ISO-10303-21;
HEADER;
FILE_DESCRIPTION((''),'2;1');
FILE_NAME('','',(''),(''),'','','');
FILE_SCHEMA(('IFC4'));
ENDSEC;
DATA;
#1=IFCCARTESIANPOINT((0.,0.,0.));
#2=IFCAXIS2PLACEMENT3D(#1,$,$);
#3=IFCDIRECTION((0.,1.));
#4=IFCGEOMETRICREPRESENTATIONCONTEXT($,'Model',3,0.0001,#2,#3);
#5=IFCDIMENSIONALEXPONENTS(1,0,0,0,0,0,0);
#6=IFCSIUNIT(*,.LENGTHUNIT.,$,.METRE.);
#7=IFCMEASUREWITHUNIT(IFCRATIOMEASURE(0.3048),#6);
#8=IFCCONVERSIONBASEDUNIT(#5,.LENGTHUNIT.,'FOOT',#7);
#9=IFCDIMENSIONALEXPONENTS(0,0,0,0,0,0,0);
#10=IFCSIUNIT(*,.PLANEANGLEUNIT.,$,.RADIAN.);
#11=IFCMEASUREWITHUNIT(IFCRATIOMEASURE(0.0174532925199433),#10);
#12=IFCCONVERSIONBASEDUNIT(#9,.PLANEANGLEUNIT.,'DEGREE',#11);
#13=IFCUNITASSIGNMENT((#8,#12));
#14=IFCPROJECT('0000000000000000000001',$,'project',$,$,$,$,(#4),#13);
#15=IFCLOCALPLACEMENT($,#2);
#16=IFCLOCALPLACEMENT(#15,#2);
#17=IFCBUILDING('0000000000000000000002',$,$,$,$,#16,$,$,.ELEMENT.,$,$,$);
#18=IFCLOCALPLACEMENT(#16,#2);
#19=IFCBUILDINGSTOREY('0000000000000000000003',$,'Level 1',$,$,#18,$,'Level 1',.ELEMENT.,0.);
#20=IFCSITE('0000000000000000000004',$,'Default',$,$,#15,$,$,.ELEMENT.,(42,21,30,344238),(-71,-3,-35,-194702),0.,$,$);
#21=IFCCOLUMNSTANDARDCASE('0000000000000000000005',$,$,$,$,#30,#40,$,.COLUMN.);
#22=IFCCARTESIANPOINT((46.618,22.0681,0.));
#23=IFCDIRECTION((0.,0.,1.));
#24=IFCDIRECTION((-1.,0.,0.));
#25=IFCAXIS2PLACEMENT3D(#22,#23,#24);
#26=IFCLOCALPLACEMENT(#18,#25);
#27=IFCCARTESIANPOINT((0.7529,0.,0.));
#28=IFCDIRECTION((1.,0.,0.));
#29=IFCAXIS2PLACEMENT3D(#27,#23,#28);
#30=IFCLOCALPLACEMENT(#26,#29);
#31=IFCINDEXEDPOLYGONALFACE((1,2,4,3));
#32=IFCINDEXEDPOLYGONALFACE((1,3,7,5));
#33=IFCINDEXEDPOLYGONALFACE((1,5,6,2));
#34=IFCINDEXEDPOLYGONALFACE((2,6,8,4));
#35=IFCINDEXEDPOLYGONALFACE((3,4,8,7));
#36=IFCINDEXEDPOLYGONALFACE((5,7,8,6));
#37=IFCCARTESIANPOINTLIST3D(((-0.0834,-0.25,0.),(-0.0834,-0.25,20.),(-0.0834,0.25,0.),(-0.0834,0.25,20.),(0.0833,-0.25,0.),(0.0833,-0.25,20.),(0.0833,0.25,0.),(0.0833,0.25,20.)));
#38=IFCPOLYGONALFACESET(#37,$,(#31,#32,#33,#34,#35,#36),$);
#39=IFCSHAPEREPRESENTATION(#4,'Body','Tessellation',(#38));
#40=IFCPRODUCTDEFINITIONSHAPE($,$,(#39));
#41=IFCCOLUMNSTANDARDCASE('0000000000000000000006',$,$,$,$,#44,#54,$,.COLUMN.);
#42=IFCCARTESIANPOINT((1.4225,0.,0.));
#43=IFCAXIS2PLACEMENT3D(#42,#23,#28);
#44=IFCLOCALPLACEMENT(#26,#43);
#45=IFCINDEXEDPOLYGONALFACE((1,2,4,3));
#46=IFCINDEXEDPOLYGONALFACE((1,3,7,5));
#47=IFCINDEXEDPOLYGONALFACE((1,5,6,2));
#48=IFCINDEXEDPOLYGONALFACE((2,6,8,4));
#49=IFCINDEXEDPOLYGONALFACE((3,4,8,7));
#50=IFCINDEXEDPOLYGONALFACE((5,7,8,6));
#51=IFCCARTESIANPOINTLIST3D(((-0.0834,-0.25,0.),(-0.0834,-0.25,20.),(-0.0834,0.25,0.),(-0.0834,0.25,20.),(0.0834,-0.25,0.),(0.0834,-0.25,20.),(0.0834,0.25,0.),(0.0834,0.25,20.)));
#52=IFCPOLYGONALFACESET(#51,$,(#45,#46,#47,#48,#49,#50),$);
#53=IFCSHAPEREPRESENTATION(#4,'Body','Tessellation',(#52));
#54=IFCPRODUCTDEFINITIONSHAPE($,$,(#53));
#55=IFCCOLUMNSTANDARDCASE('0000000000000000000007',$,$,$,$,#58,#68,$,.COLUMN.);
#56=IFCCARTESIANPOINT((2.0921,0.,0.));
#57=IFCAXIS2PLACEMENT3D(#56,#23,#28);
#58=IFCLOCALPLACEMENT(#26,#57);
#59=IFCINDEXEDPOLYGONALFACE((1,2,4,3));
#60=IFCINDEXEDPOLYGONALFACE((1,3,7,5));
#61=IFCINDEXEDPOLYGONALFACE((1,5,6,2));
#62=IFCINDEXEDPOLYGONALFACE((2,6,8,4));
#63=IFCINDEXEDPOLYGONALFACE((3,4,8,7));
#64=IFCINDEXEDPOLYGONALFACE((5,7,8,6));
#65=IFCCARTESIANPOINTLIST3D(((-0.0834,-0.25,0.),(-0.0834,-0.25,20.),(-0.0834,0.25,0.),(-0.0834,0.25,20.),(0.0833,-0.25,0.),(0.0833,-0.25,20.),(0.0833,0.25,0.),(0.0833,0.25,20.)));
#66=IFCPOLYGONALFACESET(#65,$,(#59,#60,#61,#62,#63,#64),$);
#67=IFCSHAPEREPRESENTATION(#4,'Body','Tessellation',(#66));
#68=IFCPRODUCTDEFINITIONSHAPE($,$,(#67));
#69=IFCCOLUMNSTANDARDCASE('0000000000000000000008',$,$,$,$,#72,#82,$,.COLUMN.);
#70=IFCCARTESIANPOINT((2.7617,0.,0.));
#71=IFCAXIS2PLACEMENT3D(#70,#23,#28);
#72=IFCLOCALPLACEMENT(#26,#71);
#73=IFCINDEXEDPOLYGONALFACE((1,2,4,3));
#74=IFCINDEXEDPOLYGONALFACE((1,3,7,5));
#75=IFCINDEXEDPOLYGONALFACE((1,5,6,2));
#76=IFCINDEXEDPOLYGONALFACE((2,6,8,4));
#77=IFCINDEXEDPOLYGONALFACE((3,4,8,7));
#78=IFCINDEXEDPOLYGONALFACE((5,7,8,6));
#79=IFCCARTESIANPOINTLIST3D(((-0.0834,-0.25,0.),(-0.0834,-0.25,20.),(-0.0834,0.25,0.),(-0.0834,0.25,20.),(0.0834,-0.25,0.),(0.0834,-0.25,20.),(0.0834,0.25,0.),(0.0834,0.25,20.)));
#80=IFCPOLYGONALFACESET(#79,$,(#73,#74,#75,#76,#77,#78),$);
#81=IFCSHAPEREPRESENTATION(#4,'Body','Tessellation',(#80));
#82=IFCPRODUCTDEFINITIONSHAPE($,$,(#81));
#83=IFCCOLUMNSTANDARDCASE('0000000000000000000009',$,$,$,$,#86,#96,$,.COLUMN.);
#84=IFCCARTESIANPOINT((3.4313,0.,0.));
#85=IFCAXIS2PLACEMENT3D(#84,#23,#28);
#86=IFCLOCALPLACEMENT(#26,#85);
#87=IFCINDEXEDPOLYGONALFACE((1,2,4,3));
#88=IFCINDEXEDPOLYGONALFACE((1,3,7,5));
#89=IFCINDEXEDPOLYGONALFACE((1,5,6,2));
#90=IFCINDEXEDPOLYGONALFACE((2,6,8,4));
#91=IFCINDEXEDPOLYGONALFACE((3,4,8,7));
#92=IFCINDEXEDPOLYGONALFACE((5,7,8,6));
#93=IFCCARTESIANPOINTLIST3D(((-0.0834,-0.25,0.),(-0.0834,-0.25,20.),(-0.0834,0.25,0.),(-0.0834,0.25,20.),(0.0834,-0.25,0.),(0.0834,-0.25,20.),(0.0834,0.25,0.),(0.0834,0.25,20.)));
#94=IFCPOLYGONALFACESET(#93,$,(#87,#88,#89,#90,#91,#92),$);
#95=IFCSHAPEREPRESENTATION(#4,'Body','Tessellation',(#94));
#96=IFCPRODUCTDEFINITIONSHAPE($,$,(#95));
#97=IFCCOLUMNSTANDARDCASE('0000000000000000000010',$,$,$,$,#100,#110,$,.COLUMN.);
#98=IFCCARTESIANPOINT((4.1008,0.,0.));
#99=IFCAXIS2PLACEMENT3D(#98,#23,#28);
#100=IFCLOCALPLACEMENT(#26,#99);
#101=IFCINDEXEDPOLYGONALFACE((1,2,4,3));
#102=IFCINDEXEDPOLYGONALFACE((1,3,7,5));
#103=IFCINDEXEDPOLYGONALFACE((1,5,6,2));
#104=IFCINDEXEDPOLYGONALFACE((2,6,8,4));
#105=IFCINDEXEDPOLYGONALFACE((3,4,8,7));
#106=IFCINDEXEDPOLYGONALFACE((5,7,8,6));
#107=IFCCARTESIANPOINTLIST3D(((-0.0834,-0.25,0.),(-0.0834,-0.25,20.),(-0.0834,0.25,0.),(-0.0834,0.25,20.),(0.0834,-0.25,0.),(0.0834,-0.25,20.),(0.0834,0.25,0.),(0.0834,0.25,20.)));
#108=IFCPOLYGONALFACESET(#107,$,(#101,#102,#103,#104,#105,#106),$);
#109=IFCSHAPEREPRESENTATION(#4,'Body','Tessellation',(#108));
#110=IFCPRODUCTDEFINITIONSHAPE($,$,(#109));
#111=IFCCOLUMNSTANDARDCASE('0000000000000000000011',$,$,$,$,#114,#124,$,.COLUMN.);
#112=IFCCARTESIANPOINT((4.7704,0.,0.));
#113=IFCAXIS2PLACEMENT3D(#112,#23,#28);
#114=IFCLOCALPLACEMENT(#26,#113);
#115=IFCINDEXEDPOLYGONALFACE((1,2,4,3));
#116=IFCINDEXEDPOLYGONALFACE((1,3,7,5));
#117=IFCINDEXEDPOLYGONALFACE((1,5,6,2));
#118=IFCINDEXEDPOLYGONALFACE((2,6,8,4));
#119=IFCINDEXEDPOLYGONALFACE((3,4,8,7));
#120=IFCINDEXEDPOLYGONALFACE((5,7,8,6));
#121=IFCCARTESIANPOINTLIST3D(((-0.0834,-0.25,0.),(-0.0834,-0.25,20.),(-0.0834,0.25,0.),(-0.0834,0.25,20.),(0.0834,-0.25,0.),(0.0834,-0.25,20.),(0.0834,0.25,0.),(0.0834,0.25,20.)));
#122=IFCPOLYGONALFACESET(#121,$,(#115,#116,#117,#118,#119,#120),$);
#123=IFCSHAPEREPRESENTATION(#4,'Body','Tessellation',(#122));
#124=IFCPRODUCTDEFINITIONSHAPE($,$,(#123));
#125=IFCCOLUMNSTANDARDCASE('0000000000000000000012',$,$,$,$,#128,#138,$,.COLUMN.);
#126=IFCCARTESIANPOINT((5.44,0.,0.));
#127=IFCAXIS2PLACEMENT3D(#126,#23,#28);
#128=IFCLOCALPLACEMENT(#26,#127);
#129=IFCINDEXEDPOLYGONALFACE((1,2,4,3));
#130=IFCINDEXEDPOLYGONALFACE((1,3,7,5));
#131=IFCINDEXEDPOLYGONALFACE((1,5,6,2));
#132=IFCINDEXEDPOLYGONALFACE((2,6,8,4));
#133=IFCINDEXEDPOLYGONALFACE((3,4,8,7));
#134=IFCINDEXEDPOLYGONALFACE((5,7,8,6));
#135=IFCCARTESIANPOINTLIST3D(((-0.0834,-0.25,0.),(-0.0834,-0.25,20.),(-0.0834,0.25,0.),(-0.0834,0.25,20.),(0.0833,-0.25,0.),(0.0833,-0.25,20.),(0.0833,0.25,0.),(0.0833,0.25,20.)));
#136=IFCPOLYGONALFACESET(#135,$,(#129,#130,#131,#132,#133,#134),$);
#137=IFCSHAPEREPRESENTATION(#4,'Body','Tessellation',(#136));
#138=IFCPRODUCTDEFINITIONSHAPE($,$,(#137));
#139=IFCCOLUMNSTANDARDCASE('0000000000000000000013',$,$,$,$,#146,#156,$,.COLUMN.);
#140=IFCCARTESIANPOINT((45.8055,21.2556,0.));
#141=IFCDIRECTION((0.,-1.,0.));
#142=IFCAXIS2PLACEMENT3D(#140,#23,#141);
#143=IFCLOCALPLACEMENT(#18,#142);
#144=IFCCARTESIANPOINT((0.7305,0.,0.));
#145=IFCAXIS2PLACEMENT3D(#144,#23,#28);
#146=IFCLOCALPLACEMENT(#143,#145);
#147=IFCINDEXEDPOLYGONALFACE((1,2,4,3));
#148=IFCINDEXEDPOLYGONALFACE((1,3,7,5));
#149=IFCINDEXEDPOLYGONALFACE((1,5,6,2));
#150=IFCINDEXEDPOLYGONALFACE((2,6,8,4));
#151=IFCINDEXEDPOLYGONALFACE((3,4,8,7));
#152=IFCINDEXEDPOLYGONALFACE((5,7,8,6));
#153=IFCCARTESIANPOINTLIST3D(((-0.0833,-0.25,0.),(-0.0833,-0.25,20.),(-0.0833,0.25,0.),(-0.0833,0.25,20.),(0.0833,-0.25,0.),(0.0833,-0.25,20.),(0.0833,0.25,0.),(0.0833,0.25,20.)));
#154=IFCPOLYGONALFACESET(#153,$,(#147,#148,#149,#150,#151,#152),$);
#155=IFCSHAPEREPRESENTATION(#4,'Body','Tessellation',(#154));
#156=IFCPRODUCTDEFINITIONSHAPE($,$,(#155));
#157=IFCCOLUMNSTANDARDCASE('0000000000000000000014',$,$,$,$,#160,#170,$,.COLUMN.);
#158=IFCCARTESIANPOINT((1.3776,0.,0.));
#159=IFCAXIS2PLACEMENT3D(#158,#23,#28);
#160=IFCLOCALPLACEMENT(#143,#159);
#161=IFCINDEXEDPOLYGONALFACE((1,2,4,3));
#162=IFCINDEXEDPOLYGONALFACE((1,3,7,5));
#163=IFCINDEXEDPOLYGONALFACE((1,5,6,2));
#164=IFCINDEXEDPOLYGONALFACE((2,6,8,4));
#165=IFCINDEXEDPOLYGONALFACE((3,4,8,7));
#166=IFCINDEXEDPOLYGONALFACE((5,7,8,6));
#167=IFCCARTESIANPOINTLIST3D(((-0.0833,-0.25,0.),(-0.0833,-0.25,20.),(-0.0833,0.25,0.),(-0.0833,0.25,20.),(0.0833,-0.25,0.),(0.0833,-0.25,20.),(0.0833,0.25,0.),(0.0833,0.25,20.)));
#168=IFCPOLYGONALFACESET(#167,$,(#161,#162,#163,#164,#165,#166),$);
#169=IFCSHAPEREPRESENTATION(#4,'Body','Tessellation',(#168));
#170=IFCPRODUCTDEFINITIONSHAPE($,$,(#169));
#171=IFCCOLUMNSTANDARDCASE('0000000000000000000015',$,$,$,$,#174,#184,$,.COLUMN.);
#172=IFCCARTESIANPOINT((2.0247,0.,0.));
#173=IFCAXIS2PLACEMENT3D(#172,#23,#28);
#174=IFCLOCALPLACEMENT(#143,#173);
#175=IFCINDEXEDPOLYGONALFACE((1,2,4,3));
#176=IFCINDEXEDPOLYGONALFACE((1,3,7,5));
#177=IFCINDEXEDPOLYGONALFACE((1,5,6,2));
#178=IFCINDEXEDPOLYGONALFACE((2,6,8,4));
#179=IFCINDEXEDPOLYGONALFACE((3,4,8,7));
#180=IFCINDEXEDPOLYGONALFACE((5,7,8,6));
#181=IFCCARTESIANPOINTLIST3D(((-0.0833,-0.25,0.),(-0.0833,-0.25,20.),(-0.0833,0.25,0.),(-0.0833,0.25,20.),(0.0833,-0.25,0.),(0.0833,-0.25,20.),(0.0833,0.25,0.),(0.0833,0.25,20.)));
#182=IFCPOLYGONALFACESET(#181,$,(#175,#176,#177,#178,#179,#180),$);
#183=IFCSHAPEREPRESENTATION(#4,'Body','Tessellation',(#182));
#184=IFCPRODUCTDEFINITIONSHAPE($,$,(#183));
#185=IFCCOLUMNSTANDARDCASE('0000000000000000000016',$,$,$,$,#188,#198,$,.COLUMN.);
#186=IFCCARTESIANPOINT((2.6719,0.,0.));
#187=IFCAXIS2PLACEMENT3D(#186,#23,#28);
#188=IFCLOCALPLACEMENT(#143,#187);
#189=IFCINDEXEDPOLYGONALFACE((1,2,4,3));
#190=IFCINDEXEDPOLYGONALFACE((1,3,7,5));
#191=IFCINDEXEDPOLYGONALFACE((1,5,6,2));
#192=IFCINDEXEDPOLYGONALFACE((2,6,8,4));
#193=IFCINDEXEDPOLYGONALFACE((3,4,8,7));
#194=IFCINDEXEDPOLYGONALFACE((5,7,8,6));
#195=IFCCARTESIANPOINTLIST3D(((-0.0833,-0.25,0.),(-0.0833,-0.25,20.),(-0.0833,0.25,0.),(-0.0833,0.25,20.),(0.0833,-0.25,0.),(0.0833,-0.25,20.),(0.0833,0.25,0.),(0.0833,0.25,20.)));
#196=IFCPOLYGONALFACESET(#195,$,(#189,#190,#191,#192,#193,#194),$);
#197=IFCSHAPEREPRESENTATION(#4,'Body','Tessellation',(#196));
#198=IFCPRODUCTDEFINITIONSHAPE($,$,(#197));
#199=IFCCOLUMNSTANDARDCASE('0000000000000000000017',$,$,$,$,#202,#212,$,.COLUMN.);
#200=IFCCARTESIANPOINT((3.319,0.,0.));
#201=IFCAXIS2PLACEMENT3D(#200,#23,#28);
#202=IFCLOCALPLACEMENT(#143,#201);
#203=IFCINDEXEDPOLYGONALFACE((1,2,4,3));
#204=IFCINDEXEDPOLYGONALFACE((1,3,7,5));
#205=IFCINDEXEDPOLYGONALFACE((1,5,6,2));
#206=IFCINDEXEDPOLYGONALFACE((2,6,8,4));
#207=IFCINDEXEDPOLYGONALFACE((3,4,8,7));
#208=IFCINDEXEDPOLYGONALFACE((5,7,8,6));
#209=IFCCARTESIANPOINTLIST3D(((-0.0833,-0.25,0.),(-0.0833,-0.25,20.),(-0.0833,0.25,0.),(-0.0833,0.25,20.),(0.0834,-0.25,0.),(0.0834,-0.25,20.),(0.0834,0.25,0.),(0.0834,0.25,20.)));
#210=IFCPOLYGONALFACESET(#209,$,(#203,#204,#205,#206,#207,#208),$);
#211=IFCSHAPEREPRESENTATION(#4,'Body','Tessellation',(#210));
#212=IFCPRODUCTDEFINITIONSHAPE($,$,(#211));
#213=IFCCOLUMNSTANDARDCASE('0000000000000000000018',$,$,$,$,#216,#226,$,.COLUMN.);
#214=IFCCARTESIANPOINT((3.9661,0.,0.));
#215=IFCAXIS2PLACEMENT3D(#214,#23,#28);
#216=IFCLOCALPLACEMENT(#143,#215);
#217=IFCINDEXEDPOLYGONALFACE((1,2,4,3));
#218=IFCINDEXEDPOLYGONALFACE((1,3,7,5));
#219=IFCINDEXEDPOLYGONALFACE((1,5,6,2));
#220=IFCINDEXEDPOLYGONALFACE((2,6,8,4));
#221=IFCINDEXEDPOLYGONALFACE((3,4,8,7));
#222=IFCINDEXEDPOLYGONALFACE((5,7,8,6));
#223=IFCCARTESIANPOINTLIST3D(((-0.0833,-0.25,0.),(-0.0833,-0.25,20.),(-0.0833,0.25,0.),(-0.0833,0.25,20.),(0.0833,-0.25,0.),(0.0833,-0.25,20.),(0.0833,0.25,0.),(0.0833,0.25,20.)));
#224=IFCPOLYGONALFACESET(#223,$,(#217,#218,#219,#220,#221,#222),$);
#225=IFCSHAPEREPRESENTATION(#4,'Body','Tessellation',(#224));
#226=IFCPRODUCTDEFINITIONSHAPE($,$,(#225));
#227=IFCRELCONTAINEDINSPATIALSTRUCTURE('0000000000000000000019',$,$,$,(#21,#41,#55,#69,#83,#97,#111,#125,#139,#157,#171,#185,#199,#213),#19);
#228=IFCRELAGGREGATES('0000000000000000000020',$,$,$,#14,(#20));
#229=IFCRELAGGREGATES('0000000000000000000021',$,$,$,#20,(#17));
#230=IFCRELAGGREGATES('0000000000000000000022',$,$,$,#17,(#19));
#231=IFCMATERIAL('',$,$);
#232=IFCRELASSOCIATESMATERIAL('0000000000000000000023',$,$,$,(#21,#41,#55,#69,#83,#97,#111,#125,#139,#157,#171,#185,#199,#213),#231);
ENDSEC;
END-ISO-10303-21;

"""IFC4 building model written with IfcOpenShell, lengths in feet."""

from ifc_helpers import new_model, entity, si_unit, converted_unit, direction, frame, origin, place, context, project, spatial, rectangle, extrude, material, element, save


model = new_model("IFC4")

# Units and contexts
model_context = context("Model", 3, precision=0.0001, world=origin(), true_north=direction((0.0, 1.0)))
ifc_project = project(units=[converted_unit("LENGTHUNIT", "FOOT", entity("IfcRatioMeasure", 0.3048), si_unit("LENGTHUNIT", "METRE"), dimensions=[1, 0, 0, 0, 0, 0, 0]), converted_unit("PLANEANGLEUNIT", "DEGREE", entity("IfcRatioMeasure", 0.0174532925199433), si_unit("PLANEANGLEUNIT", "RADIAN"), dimensions=[0, 0, 0, 0, 0, 0, 0])], contexts=[model_context])

# Site, building, storey
site_placement = place(None, origin())
site = spatial("IfcSite", under=ifc_project, at=site_placement, Name="Default", CompositionType="ELEMENT", RefLatitude=(42, 21, 30, 344238), RefLongitude=(-71, -3, -35, -194702), RefElevation=0.0)
building_placement = place(site_placement, origin())
building = spatial("IfcBuilding", under=site, at=building_placement, CompositionType="ELEMENT")
storey_placement = place(building_placement, origin())
storey = spatial("IfcBuildingStorey", under=building, at=storey_placement, Name="Level 1", LongName="Level 1", CompositionType="ELEMENT", Elevation=0.0)

# Columns
ifc_material_1 = material(Name="")
wall_1_placement = place(storey_placement, frame((46.618, 22.0681, 0.0), z_axis=(0.0, 0.0, 1.0), x_axis=(-1.0, 0.0, 0.0)))
for number, where, z_axis, x_axis in (
    (1, (0.7529, 0.0, 0.0), (0.0, 0.0, 1.0), (1.0, 0.0, 0.0)),
    (2, (1.4225, 0.0, 0.0), (0.0, 0.0, 1.0), (1.0, 0.0, 0.0)),
    (3, (2.0921, 0.0, 0.0), (0.0, 0.0, 1.0), (1.0, 0.0, 0.0)),
    (4, (2.7617, 0.0, 0.0), (0.0, 0.0, 1.0), (1.0, 0.0, 0.0)),
    (5, (3.4313, 0.0, 0.0), (0.0, 0.0, 1.0), (1.0, 0.0, 0.0)),
    (6, (4.1008, 0.0, 0.0), (0.0, 0.0, 1.0), (1.0, 0.0, 0.0)),
    (7, (4.7704, 0.0, 0.0), (0.0, 0.0, 1.0), (1.0, 0.0, 0.0)),
    (8, (5.44, 0.0, 0.0), (0.0, 0.0, 1.0), (1.0, 0.0, 0.0)),
):
    element("IfcColumnStandardCase", number, at=place(wall_1_placement, frame(where, z_axis=z_axis, x_axis=x_axis)), inside=storey, material=ifc_material_1, PredefinedType="COLUMN", context=model_context, shape_type="SweptSolid", body=[
        extrude(rectangle(XDim=0.1667, YDim=0.5), origin(), (0.0, 0.0, 1.0), 20.0),
    ])
wall_2_placement = place(storey_placement, frame((45.8055, 21.2556, 0.0), z_axis=(0.0, 0.0, 1.0), x_axis=(0.0, -1.0, 0.0)))
for number, where, z_axis, x_axis in (
    (9, (0.7305, 0.0, 0.0), (0.0, 0.0, 1.0), (1.0, 0.0, 0.0)),
    (10, (1.3776, 0.0, 0.0), (0.0, 0.0, 1.0), (1.0, 0.0, 0.0)),
    (11, (2.0247, 0.0, 0.0), (0.0, 0.0, 1.0), (1.0, 0.0, 0.0)),
    (12, (2.6719, 0.0, 0.0), (0.0, 0.0, 1.0), (1.0, 0.0, 0.0)),
    (13, (3.319, 0.0, 0.0), (0.0, 0.0, 1.0), (1.0, 0.0, 0.0)),
    (14, (3.9661, 0.0, 0.0), (0.0, 0.0, 1.0), (1.0, 0.0, 0.0)),
):
    element("IfcColumnStandardCase", number, at=place(wall_2_placement, frame(where, z_axis=z_axis, x_axis=x_axis)), inside=storey, material=ifc_material_1, PredefinedType="COLUMN", context=model_context, shape_type="SweptSolid", body=[
        extrude(rectangle(XDim=0.1667, YDim=0.5), origin(), (0.0, 0.0, 1.0), 20.0),
    ])

save(model, "model.ifc")
